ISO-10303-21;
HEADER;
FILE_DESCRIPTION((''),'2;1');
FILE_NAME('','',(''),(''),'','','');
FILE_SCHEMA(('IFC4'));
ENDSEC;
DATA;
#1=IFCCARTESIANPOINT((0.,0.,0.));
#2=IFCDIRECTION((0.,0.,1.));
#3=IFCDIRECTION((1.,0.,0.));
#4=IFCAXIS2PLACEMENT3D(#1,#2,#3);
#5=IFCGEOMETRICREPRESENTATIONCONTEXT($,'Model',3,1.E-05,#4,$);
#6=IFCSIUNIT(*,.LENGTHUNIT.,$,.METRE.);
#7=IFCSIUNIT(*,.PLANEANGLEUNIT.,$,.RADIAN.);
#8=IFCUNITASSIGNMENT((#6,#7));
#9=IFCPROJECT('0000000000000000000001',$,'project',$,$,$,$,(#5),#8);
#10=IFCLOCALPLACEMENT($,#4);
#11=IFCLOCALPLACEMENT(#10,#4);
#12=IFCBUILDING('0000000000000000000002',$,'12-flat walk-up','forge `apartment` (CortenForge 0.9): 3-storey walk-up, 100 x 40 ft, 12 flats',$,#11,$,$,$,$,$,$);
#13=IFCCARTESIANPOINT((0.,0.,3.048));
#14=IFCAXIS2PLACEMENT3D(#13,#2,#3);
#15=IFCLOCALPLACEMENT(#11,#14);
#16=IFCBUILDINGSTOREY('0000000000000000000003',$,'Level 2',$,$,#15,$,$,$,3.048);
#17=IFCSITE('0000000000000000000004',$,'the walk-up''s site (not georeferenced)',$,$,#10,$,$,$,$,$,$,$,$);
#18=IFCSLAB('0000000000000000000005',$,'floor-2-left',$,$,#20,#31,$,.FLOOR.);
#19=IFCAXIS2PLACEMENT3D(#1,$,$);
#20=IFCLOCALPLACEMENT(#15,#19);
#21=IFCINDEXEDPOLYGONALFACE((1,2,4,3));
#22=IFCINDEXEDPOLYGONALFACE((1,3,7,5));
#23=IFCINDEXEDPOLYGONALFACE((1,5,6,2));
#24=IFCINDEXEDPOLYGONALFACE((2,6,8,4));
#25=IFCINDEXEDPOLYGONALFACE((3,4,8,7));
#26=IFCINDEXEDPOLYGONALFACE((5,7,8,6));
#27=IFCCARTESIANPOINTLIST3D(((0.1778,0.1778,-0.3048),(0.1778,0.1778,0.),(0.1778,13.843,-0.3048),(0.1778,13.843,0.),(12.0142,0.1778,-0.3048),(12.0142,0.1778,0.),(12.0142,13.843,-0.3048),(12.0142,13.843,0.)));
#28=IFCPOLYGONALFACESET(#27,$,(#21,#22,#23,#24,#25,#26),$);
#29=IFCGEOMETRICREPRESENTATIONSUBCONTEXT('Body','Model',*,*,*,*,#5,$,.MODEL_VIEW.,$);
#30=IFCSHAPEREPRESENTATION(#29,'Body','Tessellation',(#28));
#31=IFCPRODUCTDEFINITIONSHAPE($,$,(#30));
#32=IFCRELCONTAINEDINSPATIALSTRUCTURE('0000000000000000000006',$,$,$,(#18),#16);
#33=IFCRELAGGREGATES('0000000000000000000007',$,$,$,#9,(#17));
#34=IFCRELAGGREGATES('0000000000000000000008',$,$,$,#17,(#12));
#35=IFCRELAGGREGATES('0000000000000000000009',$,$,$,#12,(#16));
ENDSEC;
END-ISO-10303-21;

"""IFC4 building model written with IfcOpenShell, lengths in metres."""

from ifc_helpers import new_model, si_unit, frame, frame_2d, origin, origin_with_axes, place, context, subcontext, project, spatial, rectangle, extrude, element, save


model = new_model("IFC4")

# Units and contexts
model_context = context("Model", 3, precision=1e-05, world=origin_with_axes())
body_context = subcontext(model_context, "Body", "Model", "MODEL_VIEW")
ifc_project = project(units=[si_unit("LENGTHUNIT", "METRE"), si_unit("PLANEANGLEUNIT", "RADIAN")], contexts=[model_context])

# Site, building, storey
site_placement = place(None, origin_with_axes())
site = spatial("IfcSite", under=ifc_project, at=site_placement, Name="the walk-up's site (not georeferenced)")
building_placement = place(site_placement, origin_with_axes())
building = spatial("IfcBuilding", under=site, at=building_placement, Name="12-flat walk-up", Description="forge `apartment` (CortenForge 0.9): 3-storey walk-up, 100 x 40 ft, 12 flats")
storey_placement = place(building_placement, frame((0.0, 0.0, 3.048), z_axis=(0.0, 0.0, 1.0), x_axis=(1.0, 0.0, 0.0)))
storey = spatial("IfcBuildingStorey", under=building, at=storey_placement, Name="Level 2", Elevation=3.048)

# Slab
slab_placement = place(storey_placement, frame((0.1778, 0.1778, -0.3048), z_axis=(0.0, 0.0, 1.0), x_axis=(1.0, 0.0, 0.0)))
element("IfcSlab", 1, at=slab_placement, inside=storey, Name="floor-2-left", PredefinedType="FLOOR", context=body_context, shape_type="SweptSolid", body=[
    extrude(rectangle(XDim=11.8364, YDim=13.6652, at=frame_2d((5.9182, 6.8326))), origin(), (0.0, 0.0, 1.0), 0.3048),
])

save(model, "model.ifc")
